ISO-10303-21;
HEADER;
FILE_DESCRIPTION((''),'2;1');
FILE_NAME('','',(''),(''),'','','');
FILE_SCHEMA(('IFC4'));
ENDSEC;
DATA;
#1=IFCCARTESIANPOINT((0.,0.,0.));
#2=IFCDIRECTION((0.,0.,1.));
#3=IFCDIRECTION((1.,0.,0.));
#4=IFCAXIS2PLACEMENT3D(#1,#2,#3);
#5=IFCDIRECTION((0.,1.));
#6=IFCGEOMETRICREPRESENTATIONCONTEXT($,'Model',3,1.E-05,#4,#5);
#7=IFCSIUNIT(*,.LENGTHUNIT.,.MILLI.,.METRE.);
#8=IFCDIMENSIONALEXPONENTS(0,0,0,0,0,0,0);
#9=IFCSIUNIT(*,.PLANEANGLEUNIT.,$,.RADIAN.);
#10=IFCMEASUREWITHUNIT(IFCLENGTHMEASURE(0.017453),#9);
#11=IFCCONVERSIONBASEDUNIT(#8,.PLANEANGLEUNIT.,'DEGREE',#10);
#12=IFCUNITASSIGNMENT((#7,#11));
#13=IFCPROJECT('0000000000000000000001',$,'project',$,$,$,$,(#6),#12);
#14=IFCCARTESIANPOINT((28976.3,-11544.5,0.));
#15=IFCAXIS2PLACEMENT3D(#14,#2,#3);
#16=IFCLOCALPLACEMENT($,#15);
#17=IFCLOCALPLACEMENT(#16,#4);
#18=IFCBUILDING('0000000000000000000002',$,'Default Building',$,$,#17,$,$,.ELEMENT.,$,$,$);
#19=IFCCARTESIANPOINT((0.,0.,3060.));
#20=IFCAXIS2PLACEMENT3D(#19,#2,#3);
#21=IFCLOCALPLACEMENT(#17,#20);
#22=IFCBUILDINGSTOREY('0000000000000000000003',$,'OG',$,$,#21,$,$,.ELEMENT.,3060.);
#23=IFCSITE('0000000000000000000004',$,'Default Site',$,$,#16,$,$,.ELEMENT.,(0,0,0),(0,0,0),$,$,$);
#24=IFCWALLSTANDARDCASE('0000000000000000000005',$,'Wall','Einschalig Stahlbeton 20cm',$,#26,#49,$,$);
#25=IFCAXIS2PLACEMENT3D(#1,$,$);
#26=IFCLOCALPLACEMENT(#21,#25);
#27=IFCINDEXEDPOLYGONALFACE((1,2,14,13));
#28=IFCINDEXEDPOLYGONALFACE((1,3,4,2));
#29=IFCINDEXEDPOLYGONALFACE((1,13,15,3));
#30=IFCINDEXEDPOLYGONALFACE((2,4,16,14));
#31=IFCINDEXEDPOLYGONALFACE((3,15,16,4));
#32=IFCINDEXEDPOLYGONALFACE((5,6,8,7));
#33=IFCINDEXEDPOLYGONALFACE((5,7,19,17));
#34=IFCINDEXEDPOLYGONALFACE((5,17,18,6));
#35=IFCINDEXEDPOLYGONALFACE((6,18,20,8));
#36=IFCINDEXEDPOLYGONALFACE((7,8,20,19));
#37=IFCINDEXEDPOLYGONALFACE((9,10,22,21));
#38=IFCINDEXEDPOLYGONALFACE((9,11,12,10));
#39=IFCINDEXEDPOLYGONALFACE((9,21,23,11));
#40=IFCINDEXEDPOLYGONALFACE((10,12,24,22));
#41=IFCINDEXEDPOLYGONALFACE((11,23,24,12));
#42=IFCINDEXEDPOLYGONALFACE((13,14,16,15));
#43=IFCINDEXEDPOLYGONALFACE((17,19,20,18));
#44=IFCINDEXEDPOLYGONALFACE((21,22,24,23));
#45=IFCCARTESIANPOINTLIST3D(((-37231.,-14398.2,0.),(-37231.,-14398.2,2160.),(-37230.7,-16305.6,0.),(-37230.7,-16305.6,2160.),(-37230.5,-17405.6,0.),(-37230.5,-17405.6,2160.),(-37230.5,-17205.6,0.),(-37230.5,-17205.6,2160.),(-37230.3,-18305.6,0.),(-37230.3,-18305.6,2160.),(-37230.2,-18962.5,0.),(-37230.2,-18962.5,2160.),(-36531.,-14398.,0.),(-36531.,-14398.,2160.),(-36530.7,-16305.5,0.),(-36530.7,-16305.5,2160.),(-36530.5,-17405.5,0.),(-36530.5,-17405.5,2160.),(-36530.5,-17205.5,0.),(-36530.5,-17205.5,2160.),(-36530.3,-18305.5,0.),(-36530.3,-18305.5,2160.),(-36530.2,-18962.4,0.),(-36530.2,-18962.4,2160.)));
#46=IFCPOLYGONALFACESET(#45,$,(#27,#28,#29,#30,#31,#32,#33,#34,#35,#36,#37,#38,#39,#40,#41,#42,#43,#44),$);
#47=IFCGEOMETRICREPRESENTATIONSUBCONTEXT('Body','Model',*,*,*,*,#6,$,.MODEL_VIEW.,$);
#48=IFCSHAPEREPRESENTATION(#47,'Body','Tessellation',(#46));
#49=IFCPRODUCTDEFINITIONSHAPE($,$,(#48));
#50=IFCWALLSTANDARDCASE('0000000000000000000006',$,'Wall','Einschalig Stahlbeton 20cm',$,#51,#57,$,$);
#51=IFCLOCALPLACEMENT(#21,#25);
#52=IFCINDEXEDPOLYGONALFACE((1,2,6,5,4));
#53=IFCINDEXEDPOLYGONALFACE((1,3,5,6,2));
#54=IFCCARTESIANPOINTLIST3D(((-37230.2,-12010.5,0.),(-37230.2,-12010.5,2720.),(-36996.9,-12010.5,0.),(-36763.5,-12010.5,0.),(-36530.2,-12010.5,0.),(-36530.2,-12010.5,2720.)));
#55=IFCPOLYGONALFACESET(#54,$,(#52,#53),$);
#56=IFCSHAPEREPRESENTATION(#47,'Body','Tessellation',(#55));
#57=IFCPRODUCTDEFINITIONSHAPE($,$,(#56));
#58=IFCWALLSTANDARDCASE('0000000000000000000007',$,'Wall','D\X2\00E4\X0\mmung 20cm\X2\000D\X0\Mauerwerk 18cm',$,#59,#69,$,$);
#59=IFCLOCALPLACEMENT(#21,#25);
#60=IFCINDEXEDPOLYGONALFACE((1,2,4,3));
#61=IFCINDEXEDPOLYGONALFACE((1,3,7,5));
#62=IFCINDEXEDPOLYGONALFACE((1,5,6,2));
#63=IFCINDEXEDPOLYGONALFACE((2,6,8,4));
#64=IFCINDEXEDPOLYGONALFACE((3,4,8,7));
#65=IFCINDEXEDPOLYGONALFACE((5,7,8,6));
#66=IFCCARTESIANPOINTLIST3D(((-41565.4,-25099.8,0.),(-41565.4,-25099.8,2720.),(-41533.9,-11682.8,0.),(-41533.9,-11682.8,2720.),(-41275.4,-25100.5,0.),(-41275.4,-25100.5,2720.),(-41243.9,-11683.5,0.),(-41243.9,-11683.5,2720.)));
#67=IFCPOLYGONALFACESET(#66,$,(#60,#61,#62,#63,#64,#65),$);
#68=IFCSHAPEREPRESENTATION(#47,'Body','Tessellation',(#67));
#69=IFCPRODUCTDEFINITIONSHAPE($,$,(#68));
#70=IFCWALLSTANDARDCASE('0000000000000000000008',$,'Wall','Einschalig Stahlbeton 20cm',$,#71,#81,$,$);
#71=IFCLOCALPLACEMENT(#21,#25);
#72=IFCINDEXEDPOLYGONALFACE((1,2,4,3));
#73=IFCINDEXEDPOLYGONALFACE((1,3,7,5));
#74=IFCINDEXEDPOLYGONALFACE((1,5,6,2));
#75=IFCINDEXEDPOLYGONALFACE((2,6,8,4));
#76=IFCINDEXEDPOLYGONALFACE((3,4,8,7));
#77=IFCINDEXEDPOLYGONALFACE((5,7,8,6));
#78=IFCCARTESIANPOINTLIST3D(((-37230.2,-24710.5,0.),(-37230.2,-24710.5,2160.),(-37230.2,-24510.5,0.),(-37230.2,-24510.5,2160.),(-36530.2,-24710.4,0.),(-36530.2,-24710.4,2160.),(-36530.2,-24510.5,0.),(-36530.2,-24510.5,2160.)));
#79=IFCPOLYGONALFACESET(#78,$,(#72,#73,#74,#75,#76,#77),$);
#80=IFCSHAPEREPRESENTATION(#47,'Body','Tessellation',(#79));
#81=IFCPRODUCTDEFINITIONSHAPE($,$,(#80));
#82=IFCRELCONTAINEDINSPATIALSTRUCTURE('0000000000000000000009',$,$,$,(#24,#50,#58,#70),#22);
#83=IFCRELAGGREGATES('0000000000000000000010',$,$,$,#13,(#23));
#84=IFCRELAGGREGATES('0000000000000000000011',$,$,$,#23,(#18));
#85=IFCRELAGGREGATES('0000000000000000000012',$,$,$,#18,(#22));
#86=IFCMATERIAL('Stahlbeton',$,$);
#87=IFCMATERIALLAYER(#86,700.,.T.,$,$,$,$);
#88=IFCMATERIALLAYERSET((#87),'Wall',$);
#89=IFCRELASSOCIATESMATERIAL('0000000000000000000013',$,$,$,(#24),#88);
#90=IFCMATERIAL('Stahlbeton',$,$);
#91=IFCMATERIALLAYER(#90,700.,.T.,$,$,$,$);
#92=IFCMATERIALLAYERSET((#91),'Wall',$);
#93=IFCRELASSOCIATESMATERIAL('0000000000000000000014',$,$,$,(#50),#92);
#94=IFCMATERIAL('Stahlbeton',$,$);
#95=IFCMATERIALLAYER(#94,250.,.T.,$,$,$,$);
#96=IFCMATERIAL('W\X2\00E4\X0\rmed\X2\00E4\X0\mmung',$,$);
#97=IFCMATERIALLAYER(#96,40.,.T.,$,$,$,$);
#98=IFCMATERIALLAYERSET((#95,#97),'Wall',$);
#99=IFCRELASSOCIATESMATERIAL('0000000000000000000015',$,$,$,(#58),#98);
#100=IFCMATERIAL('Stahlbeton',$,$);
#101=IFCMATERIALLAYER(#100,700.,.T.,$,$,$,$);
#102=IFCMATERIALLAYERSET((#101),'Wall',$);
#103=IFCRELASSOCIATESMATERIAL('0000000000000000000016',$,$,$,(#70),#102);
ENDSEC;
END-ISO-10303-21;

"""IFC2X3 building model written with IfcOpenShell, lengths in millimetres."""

from ifc_helpers import new_model, entity, si_unit, converted_unit, direction, frame, origin_with_axes, place, context, subcontext, project, spatial, polyline, outline, extrude, material, layer, layer_set, layer_usage, element, save


model = new_model("IFC2X3")

# Units and contexts
model_context = context("Model", 3, precision=1e-05, world=origin_with_axes(), true_north=direction((0.0, 1.0)))
body_context = subcontext(model_context, "Body", "Model", "MODEL_VIEW")
ifc_project = project(units=[si_unit("LENGTHUNIT", "METRE", prefix="MILLI"), converted_unit("PLANEANGLEUNIT", "DEGREE", entity("IfcLengthMeasure", 0.017453), si_unit("PLANEANGLEUNIT", "RADIAN"), dimensions=[0, 0, 0, 0, 0, 0, 0])], contexts=[model_context])

# Site, building, storey
site_placement = place(None, frame((28976.3, -11544.5, 0.0), z_axis=(0.0, 0.0, 1.0), x_axis=(1.0, 0.0, 0.0)))
site = spatial("IfcSite", under=ifc_project, at=site_placement, Name="Default Site", CompositionType="ELEMENT", RefLatitude=(0, 0, 0), RefLongitude=(0, 0, 0))
building_placement = place(site_placement, origin_with_axes())
building = spatial("IfcBuilding", under=site, at=building_placement, Name="Default Building", CompositionType="ELEMENT")
storey_placement = place(building_placement, frame((0.0, 0.0, 3060.0), z_axis=(0.0, 0.0, 1.0), x_axis=(1.0, 0.0, 0.0)))
storey = spatial("IfcBuildingStorey", under=building, at=storey_placement, Name="OG", CompositionType="ELEMENT", Elevation=3060.0)

# Wall, openings
ifc_material_1 = material(Name="Stahlbeton")
ifc_layer_1 = layer(ifc_material_1, 700.0, ventilated=True)
ifc_layer_set_1 = layer_set([ifc_layer_1], Name="Wall")
ifc_layer_usage_1 = layer_usage(ifc_layer_set_1, "AXIS2", "POSITIVE", -350.0)
wall_1_placement = place(storey_placement, frame((-36880.2, -18962.5, 0.0), z_axis=(0.0, 0.0, 1.0), x_axis=(-0.000176, 1.0, 0.0)))
wall_1 = element("IfcWallStandardCase", 1, at=wall_1_placement, inside=storey, material=ifc_layer_usage_1, Name="Wall", Description="Einschalig Stahlbeton 20cm", context=body_context, shape_type="SweptSolid", body=[
    extrude(outline(polyline([(0.0, -350.0), (0.0, 350.0), (4564.3, 350.0), (4564.3, -350.0), (0.0, -350.0)])), origin_with_axes(), (0.0, 0.0, 1.0), 2160.0),
])
opening_1_placement = place(wall_1_placement, frame((2656.9, 0.0, 0.0), z_axis=(0.0, -1.0, 0.0), x_axis=(0.0, 0.0, 1.0)))
element("IfcOpeningElement", 2, at=opening_1_placement, cuts=wall_1, context=body_context, shape_type="SweptSolid", body=[
    extrude(outline(polyline([(0.0, 0.0), (2160.0, 0.0), (2160.0, 900.0), (0.0, 900.0), (0.0, 0.0), (0.0, 0.0)])), frame((0.0, 0.0, 700.0), z_axis=(0.0, 0.0, 1.0), x_axis=(1.0, 0.0, 0.0)), (0.0, 0.0, -1.0), 1400.0),
])
opening_2_placement = place(wall_1_placement, frame((656.9, 0.0, 0.0), z_axis=(0.0, 1.0, 0.0), x_axis=(0.0, 0.0, 1.0)))
element("IfcOpeningElement", 3, at=opening_2_placement, cuts=wall_1, context=body_context, shape_type="SweptSolid", body=[
    extrude(outline(polyline([(0.0, 0.0), (2160.0, 0.0), (2160.0, 900.0), (0.0, 900.0), (0.0, 0.0), (0.0, 0.0)])), frame((0.0, 0.0, 700.0), z_axis=(0.0, 0.0, 1.0), x_axis=(1.0, 0.0, 0.0)), (0.0, 0.0, -1.0), 1400.0),
])

# Walls
ifc_material_2 = material(Name="Stahlbeton")
ifc_layer_2 = layer(ifc_material_2, 700.0, ventilated=True)
ifc_layer_set_2 = layer_set([ifc_layer_2], Name="Wall")
ifc_layer_usage_2 = layer_usage(ifc_layer_set_2, "AXIS2", "POSITIVE", -350.0)
wall_2_placement = place(storey_placement, frame((-36880.2, -12010.5, 0.0), z_axis=(0.0, 0.0, 1.0), x_axis=(0.0, 1.0, 0.0)))
element("IfcWallStandardCase", 4, at=wall_2_placement, inside=storey, material=ifc_layer_usage_2, Name="Wall", Description="Einschalig Stahlbeton 20cm", context=body_context, shape_type="SweptSolid", body=[
    extrude(outline(polyline([(0.0, -350.0), (0.0, 350.0), (0.0, 350.0), (0.0, -350.0), (0.0, -350.0)])), origin_with_axes(), (0.0, 0.0, 1.0), 2720.0),
])
ifc_material_3 = material(Name="Stahlbeton")
ifc_layer_3 = layer(ifc_material_3, 250.0, ventilated=True)
ifc_material_4 = material(Name="Wärmedämmung")
ifc_layer_4 = layer(ifc_material_4, 40.0, ventilated=True)
ifc_layer_set_3 = layer_set([ifc_layer_3, ifc_layer_4], Name="Wall")
ifc_layer_usage_3 = layer_usage(ifc_layer_set_3, "AXIS2", "POSITIVE", -145.0)
wall_3_placement = place(storey_placement, frame((-41420.4, -25100.1, 0.0), z_axis=(0.0, 0.0, 1.0), x_axis=(0.002348, 0.999997, 0.0)))
element("IfcWallStandardCase", 5, at=wall_3_placement, inside=storey, material=ifc_layer_usage_3, Name="Wall", Description="Dämmung 20cm\rMauerwerk 18cm", context=body_context, shape_type="SweptSolid", body=[
    extrude(outline(polyline([(0.0, -145.0), (0.0, 145.0), (13417.0, 145.0), (13417.0, -145.0), (0.0, -145.0)])), origin_with_axes(), (0.0, 0.0, 1.0), 2720.0),
])
ifc_material_5 = material(Name="Stahlbeton")
ifc_layer_5 = layer(ifc_material_5, 700.0, ventilated=True)
ifc_layer_set_4 = layer_set([ifc_layer_5], Name="Wall")
ifc_layer_usage_4 = layer_usage(ifc_layer_set_4, "AXIS2", "POSITIVE", -350.0)
wall_4_placement = place(storey_placement, frame((-36880.2, -24710.5, 0.0), z_axis=(0.0, 0.0, 1.0), x_axis=(-0.000019, 1.0, 0.0)))
element("IfcWallStandardCase", 6, at=wall_4_placement, inside=storey, material=ifc_layer_usage_4, Name="Wall", Description="Einschalig Stahlbeton 20cm", context=body_context, shape_type="SweptSolid", body=[
    extrude(outline(polyline([(0.0, -350.0), (0.0, 350.0), (200.0, 350.0), (200.0, -350.0), (0.0, -350.0)])), origin_with_axes(), (0.0, 0.0, 1.0), 2160.0),
])

save(model, "model.ifc")
